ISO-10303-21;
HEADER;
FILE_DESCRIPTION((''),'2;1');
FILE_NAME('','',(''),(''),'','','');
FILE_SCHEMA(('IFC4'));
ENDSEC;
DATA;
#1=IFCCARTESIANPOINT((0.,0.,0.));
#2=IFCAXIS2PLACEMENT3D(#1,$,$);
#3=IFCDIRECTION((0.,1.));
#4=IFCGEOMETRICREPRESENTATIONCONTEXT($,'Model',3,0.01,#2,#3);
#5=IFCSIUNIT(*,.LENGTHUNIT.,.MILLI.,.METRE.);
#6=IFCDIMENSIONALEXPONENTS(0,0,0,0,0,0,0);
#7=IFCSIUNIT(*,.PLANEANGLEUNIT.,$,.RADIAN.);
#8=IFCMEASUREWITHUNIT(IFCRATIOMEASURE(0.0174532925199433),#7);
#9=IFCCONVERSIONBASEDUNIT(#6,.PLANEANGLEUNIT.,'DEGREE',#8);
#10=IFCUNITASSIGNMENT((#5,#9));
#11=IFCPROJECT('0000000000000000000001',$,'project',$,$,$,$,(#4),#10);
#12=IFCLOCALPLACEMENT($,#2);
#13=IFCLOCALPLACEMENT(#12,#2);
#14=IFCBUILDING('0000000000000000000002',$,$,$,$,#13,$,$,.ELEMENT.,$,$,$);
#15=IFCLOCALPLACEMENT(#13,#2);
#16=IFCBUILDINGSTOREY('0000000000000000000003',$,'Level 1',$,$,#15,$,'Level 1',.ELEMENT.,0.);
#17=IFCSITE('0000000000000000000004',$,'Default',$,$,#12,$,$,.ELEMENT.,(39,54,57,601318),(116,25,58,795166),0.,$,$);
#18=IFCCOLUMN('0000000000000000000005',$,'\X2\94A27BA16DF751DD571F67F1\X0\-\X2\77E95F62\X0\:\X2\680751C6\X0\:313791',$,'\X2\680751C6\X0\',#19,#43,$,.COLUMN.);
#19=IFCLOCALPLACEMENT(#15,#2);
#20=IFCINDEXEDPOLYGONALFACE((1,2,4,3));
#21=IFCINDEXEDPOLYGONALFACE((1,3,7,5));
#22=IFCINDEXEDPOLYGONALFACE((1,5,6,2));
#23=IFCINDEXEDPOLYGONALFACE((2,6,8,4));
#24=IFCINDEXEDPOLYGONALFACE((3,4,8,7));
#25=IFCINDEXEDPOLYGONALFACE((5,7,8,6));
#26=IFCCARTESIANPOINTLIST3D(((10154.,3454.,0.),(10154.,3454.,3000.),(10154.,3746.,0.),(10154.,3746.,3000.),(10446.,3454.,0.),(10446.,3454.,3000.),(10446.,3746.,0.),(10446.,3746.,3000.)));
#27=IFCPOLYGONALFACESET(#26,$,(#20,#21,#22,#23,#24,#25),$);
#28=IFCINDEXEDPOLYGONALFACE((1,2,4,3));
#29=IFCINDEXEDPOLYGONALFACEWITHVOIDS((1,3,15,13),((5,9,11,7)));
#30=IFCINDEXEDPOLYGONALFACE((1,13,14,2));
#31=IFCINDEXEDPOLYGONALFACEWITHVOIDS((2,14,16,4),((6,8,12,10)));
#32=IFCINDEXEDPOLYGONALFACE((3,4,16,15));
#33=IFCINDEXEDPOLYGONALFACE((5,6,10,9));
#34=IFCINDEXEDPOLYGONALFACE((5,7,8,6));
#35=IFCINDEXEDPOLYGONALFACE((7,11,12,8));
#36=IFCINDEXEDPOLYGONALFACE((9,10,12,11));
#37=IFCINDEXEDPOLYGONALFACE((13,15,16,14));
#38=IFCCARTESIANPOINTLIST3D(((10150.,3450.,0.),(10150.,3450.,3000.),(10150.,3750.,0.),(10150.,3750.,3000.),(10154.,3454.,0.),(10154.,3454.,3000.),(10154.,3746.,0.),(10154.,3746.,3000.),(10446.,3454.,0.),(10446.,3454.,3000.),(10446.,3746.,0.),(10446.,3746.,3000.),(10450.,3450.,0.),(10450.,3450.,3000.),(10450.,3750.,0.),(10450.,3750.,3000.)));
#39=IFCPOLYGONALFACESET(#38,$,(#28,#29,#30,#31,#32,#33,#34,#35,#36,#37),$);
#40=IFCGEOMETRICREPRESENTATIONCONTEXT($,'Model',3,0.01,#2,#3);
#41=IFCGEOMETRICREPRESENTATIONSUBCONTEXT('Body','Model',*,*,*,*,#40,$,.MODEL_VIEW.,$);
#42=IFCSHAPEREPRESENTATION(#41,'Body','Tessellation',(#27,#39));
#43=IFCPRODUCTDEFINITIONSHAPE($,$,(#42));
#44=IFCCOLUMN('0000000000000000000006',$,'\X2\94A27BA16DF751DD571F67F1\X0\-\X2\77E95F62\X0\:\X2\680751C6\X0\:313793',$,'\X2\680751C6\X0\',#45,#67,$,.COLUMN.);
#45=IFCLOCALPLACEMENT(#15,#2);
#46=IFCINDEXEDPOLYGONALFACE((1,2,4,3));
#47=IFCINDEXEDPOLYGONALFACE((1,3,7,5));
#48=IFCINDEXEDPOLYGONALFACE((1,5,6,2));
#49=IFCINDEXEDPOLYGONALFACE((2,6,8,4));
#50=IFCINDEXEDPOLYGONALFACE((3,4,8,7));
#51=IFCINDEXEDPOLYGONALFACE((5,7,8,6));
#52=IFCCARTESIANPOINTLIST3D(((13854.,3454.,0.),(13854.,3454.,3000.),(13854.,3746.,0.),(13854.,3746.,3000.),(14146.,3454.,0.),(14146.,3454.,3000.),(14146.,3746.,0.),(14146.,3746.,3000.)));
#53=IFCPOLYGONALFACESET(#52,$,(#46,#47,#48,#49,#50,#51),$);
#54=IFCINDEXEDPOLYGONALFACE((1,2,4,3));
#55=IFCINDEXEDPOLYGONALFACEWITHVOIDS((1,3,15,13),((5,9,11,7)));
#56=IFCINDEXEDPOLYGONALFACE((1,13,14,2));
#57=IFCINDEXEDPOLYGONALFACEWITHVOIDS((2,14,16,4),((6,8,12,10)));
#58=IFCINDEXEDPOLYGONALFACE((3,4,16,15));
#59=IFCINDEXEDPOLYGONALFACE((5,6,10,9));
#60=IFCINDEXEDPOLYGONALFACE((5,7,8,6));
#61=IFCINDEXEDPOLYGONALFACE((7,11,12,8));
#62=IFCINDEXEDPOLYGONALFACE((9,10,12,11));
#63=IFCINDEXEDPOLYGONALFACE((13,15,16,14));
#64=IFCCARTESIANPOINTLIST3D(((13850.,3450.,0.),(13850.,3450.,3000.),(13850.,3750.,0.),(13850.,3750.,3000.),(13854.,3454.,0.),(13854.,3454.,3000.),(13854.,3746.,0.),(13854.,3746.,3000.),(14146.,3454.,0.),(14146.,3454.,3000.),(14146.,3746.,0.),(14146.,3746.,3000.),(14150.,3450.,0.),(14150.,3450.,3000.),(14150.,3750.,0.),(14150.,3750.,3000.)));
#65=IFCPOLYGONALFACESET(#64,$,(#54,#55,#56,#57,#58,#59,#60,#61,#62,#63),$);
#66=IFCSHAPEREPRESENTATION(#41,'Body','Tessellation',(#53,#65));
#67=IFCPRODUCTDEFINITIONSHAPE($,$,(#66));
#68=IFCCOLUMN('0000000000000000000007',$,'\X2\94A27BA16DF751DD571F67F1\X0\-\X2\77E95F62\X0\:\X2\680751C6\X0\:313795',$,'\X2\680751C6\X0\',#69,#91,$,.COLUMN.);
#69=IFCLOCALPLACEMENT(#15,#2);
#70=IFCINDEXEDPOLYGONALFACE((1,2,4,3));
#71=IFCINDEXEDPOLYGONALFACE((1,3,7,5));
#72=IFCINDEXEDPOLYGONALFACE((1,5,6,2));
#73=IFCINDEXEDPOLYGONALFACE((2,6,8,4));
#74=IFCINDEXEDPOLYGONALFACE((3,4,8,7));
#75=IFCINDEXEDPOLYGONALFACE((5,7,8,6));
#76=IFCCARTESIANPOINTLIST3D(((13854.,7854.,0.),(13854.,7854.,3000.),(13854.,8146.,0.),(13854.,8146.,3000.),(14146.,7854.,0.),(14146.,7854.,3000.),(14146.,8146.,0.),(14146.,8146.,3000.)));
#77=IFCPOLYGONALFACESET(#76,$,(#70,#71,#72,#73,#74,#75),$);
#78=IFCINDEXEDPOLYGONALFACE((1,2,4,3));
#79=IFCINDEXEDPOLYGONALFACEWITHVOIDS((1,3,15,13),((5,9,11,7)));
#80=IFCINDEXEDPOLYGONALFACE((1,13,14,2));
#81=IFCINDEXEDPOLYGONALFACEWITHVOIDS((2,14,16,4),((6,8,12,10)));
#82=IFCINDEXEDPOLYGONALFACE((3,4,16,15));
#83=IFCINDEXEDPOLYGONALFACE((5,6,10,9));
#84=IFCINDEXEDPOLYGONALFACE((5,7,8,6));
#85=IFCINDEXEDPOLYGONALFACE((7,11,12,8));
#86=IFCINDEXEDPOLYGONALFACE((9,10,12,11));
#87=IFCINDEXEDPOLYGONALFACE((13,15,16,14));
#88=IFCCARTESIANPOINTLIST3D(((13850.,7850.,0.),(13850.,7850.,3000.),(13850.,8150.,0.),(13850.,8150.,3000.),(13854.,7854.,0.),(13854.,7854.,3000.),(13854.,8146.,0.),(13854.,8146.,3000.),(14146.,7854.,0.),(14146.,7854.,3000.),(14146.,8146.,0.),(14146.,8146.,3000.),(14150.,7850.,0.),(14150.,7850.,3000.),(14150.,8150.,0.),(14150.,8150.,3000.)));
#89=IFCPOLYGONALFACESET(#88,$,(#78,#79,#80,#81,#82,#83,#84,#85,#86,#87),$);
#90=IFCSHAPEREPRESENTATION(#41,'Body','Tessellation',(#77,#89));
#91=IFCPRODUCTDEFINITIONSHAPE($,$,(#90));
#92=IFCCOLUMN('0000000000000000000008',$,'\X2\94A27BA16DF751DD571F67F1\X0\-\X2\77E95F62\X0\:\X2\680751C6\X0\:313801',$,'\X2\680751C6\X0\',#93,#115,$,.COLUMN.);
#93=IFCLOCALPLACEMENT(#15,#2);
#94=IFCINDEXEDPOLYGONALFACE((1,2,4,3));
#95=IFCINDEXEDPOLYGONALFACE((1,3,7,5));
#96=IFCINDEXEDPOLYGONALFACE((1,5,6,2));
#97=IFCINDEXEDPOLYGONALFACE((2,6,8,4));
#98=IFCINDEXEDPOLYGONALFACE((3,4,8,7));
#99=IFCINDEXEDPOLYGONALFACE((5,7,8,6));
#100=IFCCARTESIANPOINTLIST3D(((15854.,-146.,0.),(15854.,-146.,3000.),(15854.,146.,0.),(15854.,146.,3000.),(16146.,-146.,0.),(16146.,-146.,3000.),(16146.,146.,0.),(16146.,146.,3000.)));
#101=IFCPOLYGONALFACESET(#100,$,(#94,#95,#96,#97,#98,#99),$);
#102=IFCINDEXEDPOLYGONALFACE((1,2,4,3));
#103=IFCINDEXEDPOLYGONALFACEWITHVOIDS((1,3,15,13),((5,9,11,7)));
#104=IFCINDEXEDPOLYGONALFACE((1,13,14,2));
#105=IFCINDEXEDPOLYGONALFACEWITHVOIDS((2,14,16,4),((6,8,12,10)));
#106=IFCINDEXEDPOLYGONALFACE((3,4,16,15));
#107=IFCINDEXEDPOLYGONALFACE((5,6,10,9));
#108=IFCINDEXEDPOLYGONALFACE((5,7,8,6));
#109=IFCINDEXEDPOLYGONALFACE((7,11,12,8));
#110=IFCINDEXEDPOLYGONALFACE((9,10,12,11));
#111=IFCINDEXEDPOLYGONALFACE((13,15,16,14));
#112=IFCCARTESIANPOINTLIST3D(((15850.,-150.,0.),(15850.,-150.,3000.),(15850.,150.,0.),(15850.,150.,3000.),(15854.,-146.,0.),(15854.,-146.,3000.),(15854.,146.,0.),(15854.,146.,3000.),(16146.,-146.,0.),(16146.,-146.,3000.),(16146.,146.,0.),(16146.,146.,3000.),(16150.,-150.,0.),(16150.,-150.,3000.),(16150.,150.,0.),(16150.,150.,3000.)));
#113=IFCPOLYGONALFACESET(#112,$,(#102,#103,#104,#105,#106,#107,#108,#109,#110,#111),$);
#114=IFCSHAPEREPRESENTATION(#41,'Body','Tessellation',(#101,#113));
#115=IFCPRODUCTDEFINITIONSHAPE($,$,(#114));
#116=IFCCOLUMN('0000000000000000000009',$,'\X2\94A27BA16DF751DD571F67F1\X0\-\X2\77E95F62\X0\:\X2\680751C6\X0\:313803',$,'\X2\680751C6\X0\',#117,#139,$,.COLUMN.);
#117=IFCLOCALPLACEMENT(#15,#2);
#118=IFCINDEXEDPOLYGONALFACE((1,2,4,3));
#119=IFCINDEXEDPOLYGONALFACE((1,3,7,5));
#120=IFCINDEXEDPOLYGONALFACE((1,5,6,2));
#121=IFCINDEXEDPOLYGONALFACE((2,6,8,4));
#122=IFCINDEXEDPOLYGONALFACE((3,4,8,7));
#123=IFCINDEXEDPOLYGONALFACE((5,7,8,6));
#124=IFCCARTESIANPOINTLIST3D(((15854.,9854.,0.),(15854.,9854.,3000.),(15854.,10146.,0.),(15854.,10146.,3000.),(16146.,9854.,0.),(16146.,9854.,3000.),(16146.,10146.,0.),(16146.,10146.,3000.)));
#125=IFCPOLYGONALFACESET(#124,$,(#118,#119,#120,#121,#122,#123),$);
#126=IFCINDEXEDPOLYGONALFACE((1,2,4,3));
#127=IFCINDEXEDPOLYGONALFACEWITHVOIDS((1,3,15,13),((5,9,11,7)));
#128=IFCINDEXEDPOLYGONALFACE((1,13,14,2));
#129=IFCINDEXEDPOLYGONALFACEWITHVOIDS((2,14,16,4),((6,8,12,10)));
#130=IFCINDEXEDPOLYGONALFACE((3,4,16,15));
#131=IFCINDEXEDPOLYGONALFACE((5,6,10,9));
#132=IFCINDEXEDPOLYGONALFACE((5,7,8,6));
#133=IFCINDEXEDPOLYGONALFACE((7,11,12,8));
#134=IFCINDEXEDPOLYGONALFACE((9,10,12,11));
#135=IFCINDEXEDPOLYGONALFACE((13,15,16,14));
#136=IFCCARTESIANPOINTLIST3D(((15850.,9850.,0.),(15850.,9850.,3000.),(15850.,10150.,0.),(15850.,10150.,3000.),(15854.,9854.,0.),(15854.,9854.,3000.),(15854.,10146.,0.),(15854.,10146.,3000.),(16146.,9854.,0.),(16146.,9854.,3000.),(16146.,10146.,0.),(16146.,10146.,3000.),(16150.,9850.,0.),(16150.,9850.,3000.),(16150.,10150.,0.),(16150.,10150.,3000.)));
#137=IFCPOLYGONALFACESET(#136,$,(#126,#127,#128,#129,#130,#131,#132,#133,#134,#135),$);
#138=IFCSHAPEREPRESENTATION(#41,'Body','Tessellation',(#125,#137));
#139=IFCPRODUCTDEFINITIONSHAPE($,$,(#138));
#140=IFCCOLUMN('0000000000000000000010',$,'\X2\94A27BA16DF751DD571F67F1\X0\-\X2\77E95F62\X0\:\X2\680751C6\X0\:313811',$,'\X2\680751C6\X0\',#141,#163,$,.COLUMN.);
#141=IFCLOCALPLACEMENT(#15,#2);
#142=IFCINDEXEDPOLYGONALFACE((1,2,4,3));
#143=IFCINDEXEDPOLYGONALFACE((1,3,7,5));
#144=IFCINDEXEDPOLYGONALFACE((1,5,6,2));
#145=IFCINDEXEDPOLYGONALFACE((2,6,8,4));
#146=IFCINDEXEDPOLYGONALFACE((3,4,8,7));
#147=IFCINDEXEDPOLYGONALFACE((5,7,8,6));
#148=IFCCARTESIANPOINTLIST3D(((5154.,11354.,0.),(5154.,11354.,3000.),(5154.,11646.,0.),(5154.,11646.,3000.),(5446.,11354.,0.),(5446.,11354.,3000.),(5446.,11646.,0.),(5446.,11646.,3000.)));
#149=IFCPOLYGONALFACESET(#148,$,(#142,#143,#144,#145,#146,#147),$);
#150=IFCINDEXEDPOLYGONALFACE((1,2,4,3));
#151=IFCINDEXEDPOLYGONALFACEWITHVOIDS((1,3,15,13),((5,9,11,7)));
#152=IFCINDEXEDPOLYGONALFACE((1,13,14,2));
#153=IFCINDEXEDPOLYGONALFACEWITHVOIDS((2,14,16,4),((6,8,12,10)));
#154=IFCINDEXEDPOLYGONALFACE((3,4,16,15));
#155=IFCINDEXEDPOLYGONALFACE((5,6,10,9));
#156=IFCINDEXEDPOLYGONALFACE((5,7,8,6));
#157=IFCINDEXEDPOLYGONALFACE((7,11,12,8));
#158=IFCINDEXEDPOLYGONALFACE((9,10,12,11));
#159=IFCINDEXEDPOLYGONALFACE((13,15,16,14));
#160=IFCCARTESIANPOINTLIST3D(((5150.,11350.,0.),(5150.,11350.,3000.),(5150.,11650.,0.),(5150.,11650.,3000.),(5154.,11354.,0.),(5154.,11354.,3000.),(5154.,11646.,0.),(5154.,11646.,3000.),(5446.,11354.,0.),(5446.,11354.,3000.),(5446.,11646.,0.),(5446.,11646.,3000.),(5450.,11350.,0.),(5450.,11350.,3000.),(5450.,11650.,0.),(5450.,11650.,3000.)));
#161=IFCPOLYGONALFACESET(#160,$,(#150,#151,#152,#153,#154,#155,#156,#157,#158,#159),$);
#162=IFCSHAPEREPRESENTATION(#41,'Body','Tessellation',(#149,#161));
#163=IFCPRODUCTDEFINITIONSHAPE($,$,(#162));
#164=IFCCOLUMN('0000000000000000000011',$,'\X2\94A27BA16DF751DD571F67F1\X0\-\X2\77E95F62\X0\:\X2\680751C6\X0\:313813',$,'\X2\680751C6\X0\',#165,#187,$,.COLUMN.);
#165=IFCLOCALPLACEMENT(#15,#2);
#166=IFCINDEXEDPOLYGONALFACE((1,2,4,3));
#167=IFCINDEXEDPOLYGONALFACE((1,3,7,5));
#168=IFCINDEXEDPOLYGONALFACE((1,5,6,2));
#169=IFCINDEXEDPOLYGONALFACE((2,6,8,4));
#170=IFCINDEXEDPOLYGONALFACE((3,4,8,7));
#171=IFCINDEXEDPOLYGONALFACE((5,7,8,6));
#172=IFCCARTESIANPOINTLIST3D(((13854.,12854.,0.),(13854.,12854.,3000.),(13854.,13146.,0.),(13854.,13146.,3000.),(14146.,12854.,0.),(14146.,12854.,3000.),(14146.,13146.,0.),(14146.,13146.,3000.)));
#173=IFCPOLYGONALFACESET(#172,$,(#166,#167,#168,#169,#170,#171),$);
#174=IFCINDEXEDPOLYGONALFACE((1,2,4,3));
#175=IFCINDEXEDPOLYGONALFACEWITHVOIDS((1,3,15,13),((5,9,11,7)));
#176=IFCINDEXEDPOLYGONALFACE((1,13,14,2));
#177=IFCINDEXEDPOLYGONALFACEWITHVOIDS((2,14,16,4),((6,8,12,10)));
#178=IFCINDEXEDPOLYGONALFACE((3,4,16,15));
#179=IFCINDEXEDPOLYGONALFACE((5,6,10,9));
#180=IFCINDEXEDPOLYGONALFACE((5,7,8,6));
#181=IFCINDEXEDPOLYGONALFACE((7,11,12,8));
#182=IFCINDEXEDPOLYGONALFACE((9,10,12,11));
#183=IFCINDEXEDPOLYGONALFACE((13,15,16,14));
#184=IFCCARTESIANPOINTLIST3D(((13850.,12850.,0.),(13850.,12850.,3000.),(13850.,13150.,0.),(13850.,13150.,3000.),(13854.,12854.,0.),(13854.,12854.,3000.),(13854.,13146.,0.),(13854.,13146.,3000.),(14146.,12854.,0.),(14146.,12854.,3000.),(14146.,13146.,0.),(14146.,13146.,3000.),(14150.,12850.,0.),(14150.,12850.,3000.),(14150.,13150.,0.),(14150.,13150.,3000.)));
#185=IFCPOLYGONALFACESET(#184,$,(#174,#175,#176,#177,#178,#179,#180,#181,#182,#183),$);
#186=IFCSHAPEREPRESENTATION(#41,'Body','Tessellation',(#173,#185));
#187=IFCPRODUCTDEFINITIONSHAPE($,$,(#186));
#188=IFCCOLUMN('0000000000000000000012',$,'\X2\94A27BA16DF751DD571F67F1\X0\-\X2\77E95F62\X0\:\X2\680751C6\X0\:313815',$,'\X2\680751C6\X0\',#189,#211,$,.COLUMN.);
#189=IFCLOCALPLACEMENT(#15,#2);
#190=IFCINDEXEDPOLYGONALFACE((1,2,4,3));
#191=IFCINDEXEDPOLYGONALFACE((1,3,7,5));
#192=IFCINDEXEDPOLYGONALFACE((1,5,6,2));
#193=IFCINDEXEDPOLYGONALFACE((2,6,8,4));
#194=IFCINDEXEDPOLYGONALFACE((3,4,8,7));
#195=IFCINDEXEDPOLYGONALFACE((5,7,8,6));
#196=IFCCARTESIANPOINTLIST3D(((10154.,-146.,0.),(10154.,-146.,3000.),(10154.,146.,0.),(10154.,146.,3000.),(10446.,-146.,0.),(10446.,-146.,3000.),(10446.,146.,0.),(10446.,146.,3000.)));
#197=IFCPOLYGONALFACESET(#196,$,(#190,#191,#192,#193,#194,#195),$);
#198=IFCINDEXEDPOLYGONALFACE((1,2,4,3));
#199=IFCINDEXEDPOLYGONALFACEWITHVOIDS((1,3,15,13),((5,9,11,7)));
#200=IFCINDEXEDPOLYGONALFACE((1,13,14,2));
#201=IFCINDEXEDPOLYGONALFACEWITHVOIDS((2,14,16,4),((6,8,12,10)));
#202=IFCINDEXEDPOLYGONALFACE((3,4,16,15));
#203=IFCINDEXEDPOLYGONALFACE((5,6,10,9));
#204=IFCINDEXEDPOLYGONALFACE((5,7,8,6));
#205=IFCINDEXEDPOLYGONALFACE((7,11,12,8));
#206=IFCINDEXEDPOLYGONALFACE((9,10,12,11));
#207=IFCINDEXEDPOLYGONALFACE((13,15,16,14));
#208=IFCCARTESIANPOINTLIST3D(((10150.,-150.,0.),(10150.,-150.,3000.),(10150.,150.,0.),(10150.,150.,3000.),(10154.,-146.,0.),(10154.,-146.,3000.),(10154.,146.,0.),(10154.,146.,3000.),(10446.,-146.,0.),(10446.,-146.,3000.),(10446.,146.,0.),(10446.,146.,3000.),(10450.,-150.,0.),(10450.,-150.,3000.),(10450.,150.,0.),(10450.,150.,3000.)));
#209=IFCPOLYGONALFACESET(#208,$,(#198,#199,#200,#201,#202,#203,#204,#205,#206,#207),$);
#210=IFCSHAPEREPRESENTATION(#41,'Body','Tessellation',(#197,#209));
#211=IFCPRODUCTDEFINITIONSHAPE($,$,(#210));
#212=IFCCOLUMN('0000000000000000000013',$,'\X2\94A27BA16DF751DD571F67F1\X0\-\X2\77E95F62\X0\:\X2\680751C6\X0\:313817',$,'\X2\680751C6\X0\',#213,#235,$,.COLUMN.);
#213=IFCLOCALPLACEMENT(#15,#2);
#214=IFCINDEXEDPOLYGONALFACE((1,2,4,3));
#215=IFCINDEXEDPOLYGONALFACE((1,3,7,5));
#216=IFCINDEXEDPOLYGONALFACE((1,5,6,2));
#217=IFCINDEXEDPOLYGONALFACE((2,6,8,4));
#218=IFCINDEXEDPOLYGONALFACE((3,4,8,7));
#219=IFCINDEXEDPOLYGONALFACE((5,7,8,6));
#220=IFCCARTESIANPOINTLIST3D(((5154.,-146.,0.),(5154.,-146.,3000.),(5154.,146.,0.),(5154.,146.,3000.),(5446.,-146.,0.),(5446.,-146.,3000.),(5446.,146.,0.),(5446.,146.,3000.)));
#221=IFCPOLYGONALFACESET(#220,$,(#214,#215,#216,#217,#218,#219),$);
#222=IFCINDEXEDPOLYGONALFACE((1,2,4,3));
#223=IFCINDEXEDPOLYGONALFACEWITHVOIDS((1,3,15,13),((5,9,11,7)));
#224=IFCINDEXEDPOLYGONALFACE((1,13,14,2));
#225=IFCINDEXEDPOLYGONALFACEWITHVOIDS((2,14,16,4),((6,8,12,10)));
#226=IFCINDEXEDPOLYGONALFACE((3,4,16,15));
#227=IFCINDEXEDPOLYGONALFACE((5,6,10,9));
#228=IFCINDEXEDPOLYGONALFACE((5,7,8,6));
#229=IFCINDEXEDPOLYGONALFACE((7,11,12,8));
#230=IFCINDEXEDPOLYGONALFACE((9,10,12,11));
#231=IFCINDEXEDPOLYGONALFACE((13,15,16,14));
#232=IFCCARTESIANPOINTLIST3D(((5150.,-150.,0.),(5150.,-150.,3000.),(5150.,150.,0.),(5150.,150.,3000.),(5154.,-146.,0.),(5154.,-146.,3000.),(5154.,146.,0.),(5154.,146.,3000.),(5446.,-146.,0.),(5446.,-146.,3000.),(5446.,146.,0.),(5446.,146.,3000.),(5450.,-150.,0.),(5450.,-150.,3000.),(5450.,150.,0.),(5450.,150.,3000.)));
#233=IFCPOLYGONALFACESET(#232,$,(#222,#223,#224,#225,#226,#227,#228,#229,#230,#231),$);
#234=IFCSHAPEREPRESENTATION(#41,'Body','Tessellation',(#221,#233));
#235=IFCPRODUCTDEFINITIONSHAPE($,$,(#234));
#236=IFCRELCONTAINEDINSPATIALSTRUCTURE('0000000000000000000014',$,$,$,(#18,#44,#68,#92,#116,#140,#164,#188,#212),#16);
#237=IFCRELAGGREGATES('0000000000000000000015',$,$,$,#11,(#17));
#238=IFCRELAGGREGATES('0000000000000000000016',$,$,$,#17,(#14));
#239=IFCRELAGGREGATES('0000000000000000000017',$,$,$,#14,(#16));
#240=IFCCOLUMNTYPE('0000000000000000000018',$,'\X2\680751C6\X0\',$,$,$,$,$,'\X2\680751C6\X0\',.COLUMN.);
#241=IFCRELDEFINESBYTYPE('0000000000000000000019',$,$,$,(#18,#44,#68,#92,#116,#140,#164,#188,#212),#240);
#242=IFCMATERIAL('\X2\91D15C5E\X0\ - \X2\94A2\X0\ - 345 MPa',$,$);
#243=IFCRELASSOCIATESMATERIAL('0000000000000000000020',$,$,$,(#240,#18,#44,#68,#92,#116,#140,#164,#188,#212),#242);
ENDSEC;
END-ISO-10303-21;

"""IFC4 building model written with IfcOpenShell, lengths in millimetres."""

from ifc_helpers import new_model, entity, si_unit, converted_unit, direction, frame, origin, origin_2d_with_axis, place, context, subcontext, project, spatial, polyline, rectangle, outline, extrude, source, transform, mapped, material, type_object, type_shapes, element, save


model = new_model("IFC4")

# Units and contexts
model_context_1 = context("Model", 3, precision=0.01, world=origin(), true_north=direction((0.0, 1.0)))
model_context_2 = context("Model", 3, precision=0.01, world=origin(), true_north=direction((0.0, 1.0)))
body_context_1 = subcontext(model_context_2, "Body", "Model", "MODEL_VIEW")
ifc_project = project(units=[si_unit("LENGTHUNIT", "METRE", prefix="MILLI"), converted_unit("PLANEANGLEUNIT", "DEGREE", entity("IfcRatioMeasure", 0.0174532925199433), si_unit("PLANEANGLEUNIT", "RADIAN"), dimensions=[0, 0, 0, 0, 0, 0, 0])], contexts=[model_context_1])

# Site, building, storey
site_placement = place(None, origin())
site = spatial("IfcSite", under=ifc_project, at=site_placement, Name="Default", CompositionType="ELEMENT", RefLatitude=(39, 54, 57, 601318), RefLongitude=(116, 25, 58, 795166), RefElevation=0.0)
building_placement = place(site_placement, origin())
building = spatial("IfcBuilding", under=site, at=building_placement, CompositionType="ELEMENT")
storey_placement = place(building_placement, origin())
storey = spatial("IfcBuildingStorey", under=building, at=storey_placement, Name="Level 1", LongName="Level 1", CompositionType="ELEMENT", Elevation=0.0)

# Columns
ifc_material_1 = material(Name="金属 - 钢 - 345 MPa")
column_type = type_object("IfcColumnType", Name="标准", ElementType="标准", PredefinedType="COLUMN", material=ifc_material_1)
shared_shape_1 = source(origin(), body_context_1, "Body", "SweptSolid", [
    extrude(rectangle(XDim=292.0, YDim=292.0, at=origin_2d_with_axis()), frame((0.0, 0.0, 0.0), z_axis=(0.0, 0.0, 1.0), x_axis=(-1.0, 0.0, 0.0)), (0.0, 0.0, 1.0), 3000.0),
    extrude(outline(polyline([(-150.0, -150.0), (150.0, -150.0), (150.0, 150.0), (-150.0, 150.0), (-150.0, -150.0)]), holes=[polyline([(-146.0, -146.0), (-146.0, 146.0), (146.0, 146.0), (146.0, -146.0), (-146.0, -146.0)])]), frame((0.0, 0.0, 0.0), z_axis=(0.0, 0.0, 1.0), x_axis=(-1.0, 0.0, 0.0)), (0.0, 0.0, 1.0), 3000.0),
])
type_shapes(column_type, [shared_shape_1])
placement_1 = place(None, origin())
placement_2 = place(placement_1, origin())
placement_3 = place(placement_2, origin())
for number, where, name in (
    (1, (10300.0, 3600.0, 0.0), "钢管混凝土柱-矩形:标准:313791"),
    (2, (14000.0, 3600.0, 0.0), "钢管混凝土柱-矩形:标准:313793"),
    (3, (14000.0, 8000.0, 0.0), "钢管混凝土柱-矩形:标准:313795"),
    (4, (16000.0, 0.0, 0.0), "钢管混凝土柱-矩形:标准:313801"),
    (5, (16000.0, 10000.0, 0.0), "钢管混凝土柱-矩形:标准:313803"),
    (6, (5300.0, 11500.0, 0.0), "钢管混凝土柱-矩形:标准:313811"),
    (7, (14000.0, 13000.0, 0.0), "钢管混凝土柱-矩形:标准:313813"),
    (8, (10300.0, 0.0, 0.0), "钢管混凝土柱-矩形:标准:313815"),
    (9, (5300.0, 0.0, 0.0), "钢管混凝土柱-矩形:标准:313817"),
):
    element("IfcColumn", number, at=place(placement_3, frame(where)), inside=storey, type_object=column_type, material=ifc_material_1, Name=name, ObjectType="标准", PredefinedType="COLUMN", context=body_context_1, shape_type="MappedRepresentation", body=[
        mapped(shared_shape_1, transform((0.0, 0.0, 0.0), scale=1.0)),
    ])

save(model, "model.ifc")
